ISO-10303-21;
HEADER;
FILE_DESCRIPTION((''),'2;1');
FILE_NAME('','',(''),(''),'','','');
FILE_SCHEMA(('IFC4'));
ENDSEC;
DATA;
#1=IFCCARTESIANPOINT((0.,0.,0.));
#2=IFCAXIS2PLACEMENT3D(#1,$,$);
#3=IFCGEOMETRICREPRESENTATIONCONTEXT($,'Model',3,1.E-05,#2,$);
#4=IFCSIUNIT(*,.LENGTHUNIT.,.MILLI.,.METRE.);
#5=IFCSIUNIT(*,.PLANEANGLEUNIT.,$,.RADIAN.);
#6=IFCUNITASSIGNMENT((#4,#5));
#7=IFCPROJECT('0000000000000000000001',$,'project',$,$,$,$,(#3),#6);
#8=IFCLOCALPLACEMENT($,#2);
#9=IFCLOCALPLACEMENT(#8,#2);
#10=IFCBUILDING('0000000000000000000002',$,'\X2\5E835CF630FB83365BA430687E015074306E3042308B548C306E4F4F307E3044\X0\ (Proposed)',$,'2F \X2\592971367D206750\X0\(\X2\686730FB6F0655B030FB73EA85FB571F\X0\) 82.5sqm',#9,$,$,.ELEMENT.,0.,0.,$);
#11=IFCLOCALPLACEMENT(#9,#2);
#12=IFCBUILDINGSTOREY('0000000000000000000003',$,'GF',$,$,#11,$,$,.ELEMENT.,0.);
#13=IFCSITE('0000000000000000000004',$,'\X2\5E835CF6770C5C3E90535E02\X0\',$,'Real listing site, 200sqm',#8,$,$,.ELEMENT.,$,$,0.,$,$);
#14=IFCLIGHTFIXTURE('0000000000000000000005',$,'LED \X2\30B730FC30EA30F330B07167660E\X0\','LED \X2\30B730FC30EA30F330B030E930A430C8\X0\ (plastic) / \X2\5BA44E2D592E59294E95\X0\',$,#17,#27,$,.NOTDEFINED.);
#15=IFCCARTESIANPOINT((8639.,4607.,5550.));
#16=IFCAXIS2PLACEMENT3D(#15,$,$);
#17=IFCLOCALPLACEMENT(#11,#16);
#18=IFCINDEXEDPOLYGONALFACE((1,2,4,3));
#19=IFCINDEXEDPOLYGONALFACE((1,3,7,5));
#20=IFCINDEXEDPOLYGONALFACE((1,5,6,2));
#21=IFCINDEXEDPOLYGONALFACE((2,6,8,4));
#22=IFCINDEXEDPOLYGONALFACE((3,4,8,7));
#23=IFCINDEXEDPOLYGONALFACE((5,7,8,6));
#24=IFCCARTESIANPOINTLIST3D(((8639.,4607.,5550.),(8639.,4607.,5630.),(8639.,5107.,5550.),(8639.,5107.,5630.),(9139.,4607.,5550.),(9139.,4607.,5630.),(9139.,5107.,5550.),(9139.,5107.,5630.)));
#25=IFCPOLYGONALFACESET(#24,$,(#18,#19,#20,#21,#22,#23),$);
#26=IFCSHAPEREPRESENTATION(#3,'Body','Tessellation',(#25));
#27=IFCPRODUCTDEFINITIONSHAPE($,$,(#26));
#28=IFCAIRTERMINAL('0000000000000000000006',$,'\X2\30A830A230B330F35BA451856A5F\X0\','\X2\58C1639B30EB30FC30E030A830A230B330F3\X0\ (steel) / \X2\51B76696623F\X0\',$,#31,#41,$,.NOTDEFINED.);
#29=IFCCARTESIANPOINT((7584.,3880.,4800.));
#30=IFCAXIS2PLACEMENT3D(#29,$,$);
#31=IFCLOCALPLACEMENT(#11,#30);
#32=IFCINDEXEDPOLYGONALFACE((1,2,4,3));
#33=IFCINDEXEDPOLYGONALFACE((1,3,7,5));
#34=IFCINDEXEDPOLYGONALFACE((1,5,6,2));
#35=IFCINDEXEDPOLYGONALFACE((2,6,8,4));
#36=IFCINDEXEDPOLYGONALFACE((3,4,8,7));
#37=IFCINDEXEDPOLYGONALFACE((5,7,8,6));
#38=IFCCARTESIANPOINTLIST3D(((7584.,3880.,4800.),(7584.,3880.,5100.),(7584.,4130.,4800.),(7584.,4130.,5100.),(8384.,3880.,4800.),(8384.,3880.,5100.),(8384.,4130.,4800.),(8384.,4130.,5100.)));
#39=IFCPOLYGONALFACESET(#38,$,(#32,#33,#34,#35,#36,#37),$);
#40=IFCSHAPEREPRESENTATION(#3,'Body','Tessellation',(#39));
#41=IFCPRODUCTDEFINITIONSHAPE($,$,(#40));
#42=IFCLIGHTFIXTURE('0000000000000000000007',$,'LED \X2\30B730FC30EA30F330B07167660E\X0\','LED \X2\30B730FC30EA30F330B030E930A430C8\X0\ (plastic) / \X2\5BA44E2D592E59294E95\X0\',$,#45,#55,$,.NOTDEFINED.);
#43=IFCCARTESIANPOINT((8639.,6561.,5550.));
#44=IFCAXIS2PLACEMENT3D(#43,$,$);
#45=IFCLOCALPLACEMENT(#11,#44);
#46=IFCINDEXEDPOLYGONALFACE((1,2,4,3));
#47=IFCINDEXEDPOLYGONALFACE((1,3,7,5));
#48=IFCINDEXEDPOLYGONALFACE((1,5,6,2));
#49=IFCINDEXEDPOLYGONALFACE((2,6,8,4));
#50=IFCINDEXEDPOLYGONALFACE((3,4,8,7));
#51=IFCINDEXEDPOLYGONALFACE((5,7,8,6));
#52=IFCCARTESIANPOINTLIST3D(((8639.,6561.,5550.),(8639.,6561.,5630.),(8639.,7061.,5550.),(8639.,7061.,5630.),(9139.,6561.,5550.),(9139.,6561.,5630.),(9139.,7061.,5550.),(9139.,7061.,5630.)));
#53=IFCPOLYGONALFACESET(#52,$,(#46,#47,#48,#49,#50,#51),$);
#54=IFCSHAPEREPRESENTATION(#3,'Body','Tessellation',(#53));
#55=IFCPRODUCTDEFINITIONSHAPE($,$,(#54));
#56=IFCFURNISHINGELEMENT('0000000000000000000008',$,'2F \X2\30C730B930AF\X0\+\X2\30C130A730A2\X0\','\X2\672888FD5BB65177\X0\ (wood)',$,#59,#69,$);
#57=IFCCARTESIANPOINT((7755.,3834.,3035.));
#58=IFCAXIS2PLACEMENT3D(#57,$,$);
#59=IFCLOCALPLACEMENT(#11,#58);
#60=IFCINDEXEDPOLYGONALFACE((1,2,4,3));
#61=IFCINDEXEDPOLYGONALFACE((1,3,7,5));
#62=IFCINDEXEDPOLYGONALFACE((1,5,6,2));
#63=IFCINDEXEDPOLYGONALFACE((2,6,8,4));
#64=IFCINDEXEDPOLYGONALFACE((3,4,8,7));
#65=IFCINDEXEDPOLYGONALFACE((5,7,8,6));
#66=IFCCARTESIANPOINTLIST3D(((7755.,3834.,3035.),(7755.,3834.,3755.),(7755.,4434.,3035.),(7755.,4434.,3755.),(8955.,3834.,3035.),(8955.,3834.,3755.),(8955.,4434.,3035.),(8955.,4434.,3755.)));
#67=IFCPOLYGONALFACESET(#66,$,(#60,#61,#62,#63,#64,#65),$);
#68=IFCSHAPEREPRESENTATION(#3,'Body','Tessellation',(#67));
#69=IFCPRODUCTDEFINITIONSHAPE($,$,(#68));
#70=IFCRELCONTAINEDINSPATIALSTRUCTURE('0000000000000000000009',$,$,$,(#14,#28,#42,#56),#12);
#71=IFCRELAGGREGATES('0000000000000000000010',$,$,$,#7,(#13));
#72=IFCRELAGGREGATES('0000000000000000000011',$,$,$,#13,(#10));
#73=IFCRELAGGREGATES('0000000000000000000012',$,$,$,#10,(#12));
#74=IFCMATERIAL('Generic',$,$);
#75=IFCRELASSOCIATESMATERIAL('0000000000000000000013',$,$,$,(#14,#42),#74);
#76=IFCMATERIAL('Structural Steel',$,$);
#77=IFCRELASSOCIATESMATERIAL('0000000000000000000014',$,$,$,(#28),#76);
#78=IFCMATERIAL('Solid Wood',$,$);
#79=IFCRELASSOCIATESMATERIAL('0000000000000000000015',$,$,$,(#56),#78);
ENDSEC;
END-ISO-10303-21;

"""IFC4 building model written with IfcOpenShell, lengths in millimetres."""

from ifc_helpers import new_model, si_unit, frame, frame_2d, origin, place, context, project, spatial, rectangle, extrude, material, element, save


model = new_model("IFC4")

# Units and contexts
model_context = context("Model", 3, precision=1e-05, world=origin())
ifc_project = project(units=[si_unit("LENGTHUNIT", "METRE", prefix="MILLI"), si_unit("PLANEANGLEUNIT", "RADIAN")], contexts=[model_context])

# Site, building, storey
site_placement = place(None, origin())
site = spatial("IfcSite", under=ifc_project, at=site_placement, Name="広島県尾道市", ObjectType="Real listing site, 200sqm", CompositionType="ELEMENT", RefElevation=0.0)
building_placement = place(site_placement, origin())
building = spatial("IfcBuilding", under=site, at=building_placement, Name="広島・茶室と縁側のある和の住まい (Proposed)", ObjectType="2F 天然素材(桧・漆喰・珪藻土) 82.5sqm", CompositionType="ELEMENT", ElevationOfRefHeight=0.0, ElevationOfTerrain=0.0)
storey_placement = place(building_placement, origin())
storey = spatial("IfcBuildingStorey", under=building, at=storey_placement, Name="GF", CompositionType="ELEMENT", Elevation=0.0)

# Shared definitions
ifc_material_1 = material(Name="Solid Wood")

# Shared definitions
ifc_material_2 = material(Name="Structural Steel")

# Shared definitions
ifc_material_3 = material(Name="Generic")

# Light fixture
light_fixture_1_placement = place(storey_placement, frame((8639.0, 4607.0, 5550.0)))
element("IfcLightFixture", 1, at=light_fixture_1_placement, inside=storey, material=ifc_material_3, Name="LED シーリング照明", Description="LED シーリングライト (plastic) / 室中央天井", PredefinedType="NOTDEFINED", context=model_context, shape_type="SweptSolid", body=[
    extrude(rectangle(XDim=500.0, YDim=500.0, at=frame_2d((250.0, 250.0))), frame((8639.0, 4607.0, 5550.0)), (0.0, 0.0, 1.0), 80.0),
])

# Air terminal
air_terminal_1_placement = place(storey_placement, frame((7584.0, 3880.0, 4800.0)))
element("IfcAirTerminal", 2, at=air_terminal_1_placement, inside=storey, material=ifc_material_2, Name="エアコン室内機", Description="壁掛ルームエアコン (steel) / 冷暖房", PredefinedType="NOTDEFINED", context=model_context, shape_type="SweptSolid", body=[
    extrude(rectangle(XDim=800.0, YDim=250.0, at=frame_2d((400.0, 125.0))), frame((7584.0, 3880.0, 4800.0)), (0.0, 0.0, 1.0), 300.0),
])

# Light fixture
light_fixture_2_placement = place(storey_placement, frame((8639.0, 6561.0, 5550.0)))
element("IfcLightFixture", 3, at=light_fixture_2_placement, inside=storey, material=ifc_material_3, Name="LED シーリング照明", Description="LED シーリングライト (plastic) / 室中央天井", PredefinedType="NOTDEFINED", context=model_context, shape_type="SweptSolid", body=[
    extrude(rectangle(XDim=500.0, YDim=500.0, at=frame_2d((250.0, 250.0))), frame((8639.0, 6561.0, 5550.0)), (0.0, 0.0, 1.0), 80.0),
])

# Furnishing element
furnishing_placement = place(storey_placement, frame((7755.0, 3834.0, 3035.0)))
element("IfcFurnishingElement", 4, at=furnishing_placement, inside=storey, material=ifc_material_1, Name="2F デスク+チェア", Description="木製家具 (wood)", context=model_context, shape_type="SweptSolid", body=[
    extrude(rectangle(XDim=1200.0, YDim=600.0, at=frame_2d((600.0, 300.0))), frame((7755.0, 3834.0, 3035.0)), (0.0, 0.0, 1.0), 720.0),
])

save(model, "model.ifc")
